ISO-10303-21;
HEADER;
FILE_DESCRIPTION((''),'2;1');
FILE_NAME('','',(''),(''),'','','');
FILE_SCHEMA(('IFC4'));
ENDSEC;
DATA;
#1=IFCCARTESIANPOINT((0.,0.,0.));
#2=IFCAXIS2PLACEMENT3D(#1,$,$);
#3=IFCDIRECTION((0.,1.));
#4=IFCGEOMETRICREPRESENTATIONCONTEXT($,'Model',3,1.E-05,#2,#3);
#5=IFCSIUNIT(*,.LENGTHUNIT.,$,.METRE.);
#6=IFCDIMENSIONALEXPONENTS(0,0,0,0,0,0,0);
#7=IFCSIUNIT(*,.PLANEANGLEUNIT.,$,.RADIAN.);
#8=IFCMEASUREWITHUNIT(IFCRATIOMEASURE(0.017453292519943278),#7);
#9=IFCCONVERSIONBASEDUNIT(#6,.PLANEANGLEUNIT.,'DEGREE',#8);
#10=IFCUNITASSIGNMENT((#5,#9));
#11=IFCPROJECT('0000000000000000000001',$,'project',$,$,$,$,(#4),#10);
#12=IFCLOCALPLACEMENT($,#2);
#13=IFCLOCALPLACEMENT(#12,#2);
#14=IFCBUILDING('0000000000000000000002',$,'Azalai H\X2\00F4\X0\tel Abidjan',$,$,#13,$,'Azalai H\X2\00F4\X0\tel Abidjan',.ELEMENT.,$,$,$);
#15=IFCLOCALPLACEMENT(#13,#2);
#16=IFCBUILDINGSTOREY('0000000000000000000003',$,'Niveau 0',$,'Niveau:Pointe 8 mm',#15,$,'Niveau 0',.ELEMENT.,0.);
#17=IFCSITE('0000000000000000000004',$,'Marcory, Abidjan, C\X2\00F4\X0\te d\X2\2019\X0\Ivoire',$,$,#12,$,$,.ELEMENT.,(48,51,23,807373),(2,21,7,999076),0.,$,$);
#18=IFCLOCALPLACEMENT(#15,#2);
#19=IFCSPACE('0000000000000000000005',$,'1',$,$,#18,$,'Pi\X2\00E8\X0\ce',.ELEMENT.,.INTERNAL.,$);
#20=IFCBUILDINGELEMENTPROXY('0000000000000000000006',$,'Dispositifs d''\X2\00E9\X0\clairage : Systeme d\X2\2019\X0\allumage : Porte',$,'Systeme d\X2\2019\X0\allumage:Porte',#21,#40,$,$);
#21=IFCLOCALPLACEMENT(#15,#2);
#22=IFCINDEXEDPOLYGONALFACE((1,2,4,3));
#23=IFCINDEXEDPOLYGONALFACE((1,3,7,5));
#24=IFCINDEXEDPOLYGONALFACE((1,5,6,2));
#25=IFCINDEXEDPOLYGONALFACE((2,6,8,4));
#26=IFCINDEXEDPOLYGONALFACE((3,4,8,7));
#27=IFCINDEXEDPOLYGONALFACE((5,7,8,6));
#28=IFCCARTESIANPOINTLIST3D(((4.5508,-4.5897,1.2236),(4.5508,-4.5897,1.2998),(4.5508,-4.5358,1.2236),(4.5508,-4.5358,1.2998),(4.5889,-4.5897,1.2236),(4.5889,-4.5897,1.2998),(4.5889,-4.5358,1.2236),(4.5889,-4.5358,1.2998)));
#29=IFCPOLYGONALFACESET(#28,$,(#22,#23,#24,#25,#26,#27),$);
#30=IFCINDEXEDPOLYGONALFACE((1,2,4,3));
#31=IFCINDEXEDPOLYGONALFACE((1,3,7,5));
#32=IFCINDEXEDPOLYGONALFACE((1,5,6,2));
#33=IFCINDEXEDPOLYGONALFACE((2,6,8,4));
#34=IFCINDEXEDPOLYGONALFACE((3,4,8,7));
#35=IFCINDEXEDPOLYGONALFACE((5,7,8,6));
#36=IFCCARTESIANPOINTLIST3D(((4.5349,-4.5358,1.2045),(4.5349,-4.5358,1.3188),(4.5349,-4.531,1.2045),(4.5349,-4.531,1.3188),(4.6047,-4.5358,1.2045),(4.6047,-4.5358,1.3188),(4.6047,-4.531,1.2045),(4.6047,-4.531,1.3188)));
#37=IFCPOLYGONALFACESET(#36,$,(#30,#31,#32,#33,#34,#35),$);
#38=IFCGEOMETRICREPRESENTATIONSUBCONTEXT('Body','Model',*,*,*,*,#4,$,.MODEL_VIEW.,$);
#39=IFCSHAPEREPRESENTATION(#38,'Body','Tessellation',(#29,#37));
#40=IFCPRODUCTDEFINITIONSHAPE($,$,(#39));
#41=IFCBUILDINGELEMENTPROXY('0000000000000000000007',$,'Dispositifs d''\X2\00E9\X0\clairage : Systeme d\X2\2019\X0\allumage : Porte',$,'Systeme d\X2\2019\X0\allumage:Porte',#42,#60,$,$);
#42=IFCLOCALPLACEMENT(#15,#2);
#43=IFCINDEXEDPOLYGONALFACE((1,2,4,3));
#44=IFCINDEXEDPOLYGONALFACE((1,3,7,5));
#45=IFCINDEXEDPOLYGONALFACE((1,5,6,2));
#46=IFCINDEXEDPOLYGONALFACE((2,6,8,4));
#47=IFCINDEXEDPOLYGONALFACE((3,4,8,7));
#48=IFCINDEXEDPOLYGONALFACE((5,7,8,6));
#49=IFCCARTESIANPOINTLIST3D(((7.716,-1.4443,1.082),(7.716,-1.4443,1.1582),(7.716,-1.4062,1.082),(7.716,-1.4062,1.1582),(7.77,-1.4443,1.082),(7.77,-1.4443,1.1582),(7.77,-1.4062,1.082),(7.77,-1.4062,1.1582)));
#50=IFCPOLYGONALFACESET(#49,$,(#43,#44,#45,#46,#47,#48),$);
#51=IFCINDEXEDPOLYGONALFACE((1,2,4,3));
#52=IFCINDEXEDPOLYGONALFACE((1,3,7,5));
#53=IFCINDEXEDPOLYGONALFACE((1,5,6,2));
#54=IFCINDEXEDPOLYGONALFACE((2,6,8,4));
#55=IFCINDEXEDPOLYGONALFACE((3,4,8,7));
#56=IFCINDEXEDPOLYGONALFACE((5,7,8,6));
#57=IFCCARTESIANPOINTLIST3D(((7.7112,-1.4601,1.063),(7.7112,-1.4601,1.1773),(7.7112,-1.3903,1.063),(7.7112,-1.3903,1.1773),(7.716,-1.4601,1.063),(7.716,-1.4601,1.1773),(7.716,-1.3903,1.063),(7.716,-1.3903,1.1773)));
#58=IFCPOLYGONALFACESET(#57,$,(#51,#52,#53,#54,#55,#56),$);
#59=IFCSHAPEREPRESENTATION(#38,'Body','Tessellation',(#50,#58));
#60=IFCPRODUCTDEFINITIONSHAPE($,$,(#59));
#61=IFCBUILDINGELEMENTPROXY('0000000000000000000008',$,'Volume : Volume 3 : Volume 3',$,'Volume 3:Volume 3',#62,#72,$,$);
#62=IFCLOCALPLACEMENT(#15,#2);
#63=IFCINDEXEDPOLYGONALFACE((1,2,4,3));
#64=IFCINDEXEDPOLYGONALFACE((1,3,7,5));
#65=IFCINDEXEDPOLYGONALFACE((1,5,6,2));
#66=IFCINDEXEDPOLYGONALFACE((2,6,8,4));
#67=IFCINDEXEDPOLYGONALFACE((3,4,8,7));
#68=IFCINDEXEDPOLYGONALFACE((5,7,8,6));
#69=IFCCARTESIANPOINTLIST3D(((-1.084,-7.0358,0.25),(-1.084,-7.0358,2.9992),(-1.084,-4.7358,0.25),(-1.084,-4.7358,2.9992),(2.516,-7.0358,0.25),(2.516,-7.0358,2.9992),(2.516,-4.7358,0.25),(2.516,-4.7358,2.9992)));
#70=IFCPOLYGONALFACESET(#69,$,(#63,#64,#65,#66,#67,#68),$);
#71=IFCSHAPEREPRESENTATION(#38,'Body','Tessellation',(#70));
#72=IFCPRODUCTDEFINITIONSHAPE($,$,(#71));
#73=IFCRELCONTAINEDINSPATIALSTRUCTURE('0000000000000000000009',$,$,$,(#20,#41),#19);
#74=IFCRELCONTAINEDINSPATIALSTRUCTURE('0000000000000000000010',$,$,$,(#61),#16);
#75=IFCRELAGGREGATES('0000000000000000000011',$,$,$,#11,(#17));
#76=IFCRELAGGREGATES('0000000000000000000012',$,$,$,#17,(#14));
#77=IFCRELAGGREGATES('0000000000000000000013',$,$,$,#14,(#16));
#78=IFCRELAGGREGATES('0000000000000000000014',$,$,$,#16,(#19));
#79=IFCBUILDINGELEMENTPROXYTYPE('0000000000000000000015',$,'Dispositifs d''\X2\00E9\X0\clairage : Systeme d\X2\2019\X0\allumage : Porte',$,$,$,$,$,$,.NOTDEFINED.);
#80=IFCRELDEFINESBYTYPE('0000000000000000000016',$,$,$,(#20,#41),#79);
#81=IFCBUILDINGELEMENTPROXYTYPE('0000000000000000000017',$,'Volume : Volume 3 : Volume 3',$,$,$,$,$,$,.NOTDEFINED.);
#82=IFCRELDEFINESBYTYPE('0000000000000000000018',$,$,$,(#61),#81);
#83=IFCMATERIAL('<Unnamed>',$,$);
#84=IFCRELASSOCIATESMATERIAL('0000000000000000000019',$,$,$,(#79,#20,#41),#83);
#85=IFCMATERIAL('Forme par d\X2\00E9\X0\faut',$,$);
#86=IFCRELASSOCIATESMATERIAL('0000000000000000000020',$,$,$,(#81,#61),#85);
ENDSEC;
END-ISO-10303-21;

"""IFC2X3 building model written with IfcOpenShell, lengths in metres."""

from ifc_helpers import new_model, entity, si_unit, converted_unit, direction, frame, frame_2d, origin, origin_2d_with_axis, place, context, subcontext, project, spatial, rectangle, extrude, source, transform, mapped, material, type_object, type_shapes, element, save


model = new_model("IFC2X3")

# Units and contexts
model_context = context("Model", 3, precision=1e-05, world=origin(), true_north=direction((0.0, 1.0)))
body_context = subcontext(model_context, "Body", "Model", "MODEL_VIEW")
ifc_project = project(units=[si_unit("LENGTHUNIT", "METRE"), converted_unit("PLANEANGLEUNIT", "DEGREE", entity("IfcRatioMeasure", 0.017453292519943278), si_unit("PLANEANGLEUNIT", "RADIAN"), dimensions=[0, 0, 0, 0, 0, 0, 0])], contexts=[model_context])

# Site, building, storey
site_placement = place(None, origin())
site = spatial("IfcSite", under=ifc_project, at=site_placement, Name="Marcory, Abidjan, Côte d’Ivoire", CompositionType="ELEMENT", RefLatitude=(48, 51, 23, 807373), RefLongitude=(2, 21, 7, 999076), RefElevation=0.0)
building_placement = place(site_placement, origin())
building = spatial("IfcBuilding", under=site, at=building_placement, Name="Azalai Hôtel Abidjan", LongName="Azalai Hôtel Abidjan", CompositionType="ELEMENT")
storey_placement = place(building_placement, origin())
storey = spatial("IfcBuildingStorey", under=building, at=storey_placement, Name="Niveau 0", ObjectType="Niveau:Pointe 8 mm", LongName="Niveau 0", CompositionType="ELEMENT", Elevation=0.0)

# Shared definitions
ifc_material_1 = material(Name="<Unnamed>")

# Shared definitions
space_1_placement = place(storey_placement, origin())
space_1 = spatial("IfcSpace", under=storey, at=space_1_placement, Name="1", LongName="Pièce", CompositionType="ELEMENT", InteriorOrExteriorSpace="INTERNAL")

# Building element proxies
building_element_proxy_type_1 = type_object("IfcBuildingElementProxyType", Name="Dispositifs d'éclairage : Systeme d’allumage : Porte", PredefinedType="NOTDEFINED", material=ifc_material_1)
shared_shape_1 = source(origin(), body_context, "Body", "SweptSolid", [
    extrude(rectangle(XDim=0.0381, YDim=0.0762, at=origin_2d_with_axis()), frame((0.0, 0.0, -0.054), z_axis=(0.0, 0.0, 1.0), x_axis=(-1.0, 0.0, 0.0)), (0.0, 0.0, 1.0), 0.054),
    extrude(rectangle(XDim=0.0698, YDim=0.1143, at=frame_2d((0.0, 0.0), x_axis=(1.0, 0.0))), frame((0.0, 0.0, 0.0), z_axis=(0.0, 0.0, 1.0), x_axis=(-1.0, 0.0, 0.0)), (0.0, 0.0, 1.0), 0.0048),
])
type_shapes(building_element_proxy_type_1, [shared_shape_1])
for number, where, z_axis, x_axis, name in (
    (1, (4.5698, -4.5358, 1.2617), (0.0, 1.0, 0.0), (-1.0, 0.0, 0.0), "Dispositifs d'éclairage : Systeme d’allumage : Porte"),
    (2, (7.716, -1.4252, 1.1201), (-1.0, 0.0, 0.0), (0.0, -1.0, 0.0), "Dispositifs d'éclairage : Systeme d’allumage : Porte"),
):
    element("IfcBuildingElementProxy", number, at=place(space_1_placement, frame(where, z_axis=z_axis, x_axis=x_axis)), inside=space_1, type_object=building_element_proxy_type_1, material=ifc_material_1, Name=name, ObjectType="Systeme d’allumage:Porte", context=body_context, shape_type="MappedRepresentation", body=[
        mapped(shared_shape_1, transform((0.0, 0.0, 0.0), scale=1.0)),
    ])
ifc_material_2 = material(Name="Forme par défaut")
building_element_proxy_type_2 = type_object("IfcBuildingElementProxyType", Name="Volume : Volume 3 : Volume 3", PredefinedType="NOTDEFINED", material=ifc_material_2)
shared_shape_2 = source(origin(), body_context, "Body", "SweptSolid", [
    extrude(rectangle(XDim=2.7492, YDim=2.3, at=frame_2d((0.0, 0.0), x_axis=(1.0, 0.0))), frame((-1.084, -5.8858, 1.6246), z_axis=(1.0, 0.0, 0.0), x_axis=(0.0, 0.0, 1.0)), (0.0, 0.0, 1.0), 3.6),
])
type_shapes(building_element_proxy_type_2, [shared_shape_2])
proxy_1_placement = place(storey_placement, origin())
element("IfcBuildingElementProxy", 3, at=proxy_1_placement, inside=storey, type_object=building_element_proxy_type_2, material=ifc_material_2, Name="Volume : Volume 3 : Volume 3", ObjectType="Volume 3:Volume 3", context=body_context, shape_type="MappedRepresentation", body=[
    mapped(shared_shape_2, transform((0.0, 0.0, 0.0), scale=1.0)),
])

save(model, "model.ifc")
